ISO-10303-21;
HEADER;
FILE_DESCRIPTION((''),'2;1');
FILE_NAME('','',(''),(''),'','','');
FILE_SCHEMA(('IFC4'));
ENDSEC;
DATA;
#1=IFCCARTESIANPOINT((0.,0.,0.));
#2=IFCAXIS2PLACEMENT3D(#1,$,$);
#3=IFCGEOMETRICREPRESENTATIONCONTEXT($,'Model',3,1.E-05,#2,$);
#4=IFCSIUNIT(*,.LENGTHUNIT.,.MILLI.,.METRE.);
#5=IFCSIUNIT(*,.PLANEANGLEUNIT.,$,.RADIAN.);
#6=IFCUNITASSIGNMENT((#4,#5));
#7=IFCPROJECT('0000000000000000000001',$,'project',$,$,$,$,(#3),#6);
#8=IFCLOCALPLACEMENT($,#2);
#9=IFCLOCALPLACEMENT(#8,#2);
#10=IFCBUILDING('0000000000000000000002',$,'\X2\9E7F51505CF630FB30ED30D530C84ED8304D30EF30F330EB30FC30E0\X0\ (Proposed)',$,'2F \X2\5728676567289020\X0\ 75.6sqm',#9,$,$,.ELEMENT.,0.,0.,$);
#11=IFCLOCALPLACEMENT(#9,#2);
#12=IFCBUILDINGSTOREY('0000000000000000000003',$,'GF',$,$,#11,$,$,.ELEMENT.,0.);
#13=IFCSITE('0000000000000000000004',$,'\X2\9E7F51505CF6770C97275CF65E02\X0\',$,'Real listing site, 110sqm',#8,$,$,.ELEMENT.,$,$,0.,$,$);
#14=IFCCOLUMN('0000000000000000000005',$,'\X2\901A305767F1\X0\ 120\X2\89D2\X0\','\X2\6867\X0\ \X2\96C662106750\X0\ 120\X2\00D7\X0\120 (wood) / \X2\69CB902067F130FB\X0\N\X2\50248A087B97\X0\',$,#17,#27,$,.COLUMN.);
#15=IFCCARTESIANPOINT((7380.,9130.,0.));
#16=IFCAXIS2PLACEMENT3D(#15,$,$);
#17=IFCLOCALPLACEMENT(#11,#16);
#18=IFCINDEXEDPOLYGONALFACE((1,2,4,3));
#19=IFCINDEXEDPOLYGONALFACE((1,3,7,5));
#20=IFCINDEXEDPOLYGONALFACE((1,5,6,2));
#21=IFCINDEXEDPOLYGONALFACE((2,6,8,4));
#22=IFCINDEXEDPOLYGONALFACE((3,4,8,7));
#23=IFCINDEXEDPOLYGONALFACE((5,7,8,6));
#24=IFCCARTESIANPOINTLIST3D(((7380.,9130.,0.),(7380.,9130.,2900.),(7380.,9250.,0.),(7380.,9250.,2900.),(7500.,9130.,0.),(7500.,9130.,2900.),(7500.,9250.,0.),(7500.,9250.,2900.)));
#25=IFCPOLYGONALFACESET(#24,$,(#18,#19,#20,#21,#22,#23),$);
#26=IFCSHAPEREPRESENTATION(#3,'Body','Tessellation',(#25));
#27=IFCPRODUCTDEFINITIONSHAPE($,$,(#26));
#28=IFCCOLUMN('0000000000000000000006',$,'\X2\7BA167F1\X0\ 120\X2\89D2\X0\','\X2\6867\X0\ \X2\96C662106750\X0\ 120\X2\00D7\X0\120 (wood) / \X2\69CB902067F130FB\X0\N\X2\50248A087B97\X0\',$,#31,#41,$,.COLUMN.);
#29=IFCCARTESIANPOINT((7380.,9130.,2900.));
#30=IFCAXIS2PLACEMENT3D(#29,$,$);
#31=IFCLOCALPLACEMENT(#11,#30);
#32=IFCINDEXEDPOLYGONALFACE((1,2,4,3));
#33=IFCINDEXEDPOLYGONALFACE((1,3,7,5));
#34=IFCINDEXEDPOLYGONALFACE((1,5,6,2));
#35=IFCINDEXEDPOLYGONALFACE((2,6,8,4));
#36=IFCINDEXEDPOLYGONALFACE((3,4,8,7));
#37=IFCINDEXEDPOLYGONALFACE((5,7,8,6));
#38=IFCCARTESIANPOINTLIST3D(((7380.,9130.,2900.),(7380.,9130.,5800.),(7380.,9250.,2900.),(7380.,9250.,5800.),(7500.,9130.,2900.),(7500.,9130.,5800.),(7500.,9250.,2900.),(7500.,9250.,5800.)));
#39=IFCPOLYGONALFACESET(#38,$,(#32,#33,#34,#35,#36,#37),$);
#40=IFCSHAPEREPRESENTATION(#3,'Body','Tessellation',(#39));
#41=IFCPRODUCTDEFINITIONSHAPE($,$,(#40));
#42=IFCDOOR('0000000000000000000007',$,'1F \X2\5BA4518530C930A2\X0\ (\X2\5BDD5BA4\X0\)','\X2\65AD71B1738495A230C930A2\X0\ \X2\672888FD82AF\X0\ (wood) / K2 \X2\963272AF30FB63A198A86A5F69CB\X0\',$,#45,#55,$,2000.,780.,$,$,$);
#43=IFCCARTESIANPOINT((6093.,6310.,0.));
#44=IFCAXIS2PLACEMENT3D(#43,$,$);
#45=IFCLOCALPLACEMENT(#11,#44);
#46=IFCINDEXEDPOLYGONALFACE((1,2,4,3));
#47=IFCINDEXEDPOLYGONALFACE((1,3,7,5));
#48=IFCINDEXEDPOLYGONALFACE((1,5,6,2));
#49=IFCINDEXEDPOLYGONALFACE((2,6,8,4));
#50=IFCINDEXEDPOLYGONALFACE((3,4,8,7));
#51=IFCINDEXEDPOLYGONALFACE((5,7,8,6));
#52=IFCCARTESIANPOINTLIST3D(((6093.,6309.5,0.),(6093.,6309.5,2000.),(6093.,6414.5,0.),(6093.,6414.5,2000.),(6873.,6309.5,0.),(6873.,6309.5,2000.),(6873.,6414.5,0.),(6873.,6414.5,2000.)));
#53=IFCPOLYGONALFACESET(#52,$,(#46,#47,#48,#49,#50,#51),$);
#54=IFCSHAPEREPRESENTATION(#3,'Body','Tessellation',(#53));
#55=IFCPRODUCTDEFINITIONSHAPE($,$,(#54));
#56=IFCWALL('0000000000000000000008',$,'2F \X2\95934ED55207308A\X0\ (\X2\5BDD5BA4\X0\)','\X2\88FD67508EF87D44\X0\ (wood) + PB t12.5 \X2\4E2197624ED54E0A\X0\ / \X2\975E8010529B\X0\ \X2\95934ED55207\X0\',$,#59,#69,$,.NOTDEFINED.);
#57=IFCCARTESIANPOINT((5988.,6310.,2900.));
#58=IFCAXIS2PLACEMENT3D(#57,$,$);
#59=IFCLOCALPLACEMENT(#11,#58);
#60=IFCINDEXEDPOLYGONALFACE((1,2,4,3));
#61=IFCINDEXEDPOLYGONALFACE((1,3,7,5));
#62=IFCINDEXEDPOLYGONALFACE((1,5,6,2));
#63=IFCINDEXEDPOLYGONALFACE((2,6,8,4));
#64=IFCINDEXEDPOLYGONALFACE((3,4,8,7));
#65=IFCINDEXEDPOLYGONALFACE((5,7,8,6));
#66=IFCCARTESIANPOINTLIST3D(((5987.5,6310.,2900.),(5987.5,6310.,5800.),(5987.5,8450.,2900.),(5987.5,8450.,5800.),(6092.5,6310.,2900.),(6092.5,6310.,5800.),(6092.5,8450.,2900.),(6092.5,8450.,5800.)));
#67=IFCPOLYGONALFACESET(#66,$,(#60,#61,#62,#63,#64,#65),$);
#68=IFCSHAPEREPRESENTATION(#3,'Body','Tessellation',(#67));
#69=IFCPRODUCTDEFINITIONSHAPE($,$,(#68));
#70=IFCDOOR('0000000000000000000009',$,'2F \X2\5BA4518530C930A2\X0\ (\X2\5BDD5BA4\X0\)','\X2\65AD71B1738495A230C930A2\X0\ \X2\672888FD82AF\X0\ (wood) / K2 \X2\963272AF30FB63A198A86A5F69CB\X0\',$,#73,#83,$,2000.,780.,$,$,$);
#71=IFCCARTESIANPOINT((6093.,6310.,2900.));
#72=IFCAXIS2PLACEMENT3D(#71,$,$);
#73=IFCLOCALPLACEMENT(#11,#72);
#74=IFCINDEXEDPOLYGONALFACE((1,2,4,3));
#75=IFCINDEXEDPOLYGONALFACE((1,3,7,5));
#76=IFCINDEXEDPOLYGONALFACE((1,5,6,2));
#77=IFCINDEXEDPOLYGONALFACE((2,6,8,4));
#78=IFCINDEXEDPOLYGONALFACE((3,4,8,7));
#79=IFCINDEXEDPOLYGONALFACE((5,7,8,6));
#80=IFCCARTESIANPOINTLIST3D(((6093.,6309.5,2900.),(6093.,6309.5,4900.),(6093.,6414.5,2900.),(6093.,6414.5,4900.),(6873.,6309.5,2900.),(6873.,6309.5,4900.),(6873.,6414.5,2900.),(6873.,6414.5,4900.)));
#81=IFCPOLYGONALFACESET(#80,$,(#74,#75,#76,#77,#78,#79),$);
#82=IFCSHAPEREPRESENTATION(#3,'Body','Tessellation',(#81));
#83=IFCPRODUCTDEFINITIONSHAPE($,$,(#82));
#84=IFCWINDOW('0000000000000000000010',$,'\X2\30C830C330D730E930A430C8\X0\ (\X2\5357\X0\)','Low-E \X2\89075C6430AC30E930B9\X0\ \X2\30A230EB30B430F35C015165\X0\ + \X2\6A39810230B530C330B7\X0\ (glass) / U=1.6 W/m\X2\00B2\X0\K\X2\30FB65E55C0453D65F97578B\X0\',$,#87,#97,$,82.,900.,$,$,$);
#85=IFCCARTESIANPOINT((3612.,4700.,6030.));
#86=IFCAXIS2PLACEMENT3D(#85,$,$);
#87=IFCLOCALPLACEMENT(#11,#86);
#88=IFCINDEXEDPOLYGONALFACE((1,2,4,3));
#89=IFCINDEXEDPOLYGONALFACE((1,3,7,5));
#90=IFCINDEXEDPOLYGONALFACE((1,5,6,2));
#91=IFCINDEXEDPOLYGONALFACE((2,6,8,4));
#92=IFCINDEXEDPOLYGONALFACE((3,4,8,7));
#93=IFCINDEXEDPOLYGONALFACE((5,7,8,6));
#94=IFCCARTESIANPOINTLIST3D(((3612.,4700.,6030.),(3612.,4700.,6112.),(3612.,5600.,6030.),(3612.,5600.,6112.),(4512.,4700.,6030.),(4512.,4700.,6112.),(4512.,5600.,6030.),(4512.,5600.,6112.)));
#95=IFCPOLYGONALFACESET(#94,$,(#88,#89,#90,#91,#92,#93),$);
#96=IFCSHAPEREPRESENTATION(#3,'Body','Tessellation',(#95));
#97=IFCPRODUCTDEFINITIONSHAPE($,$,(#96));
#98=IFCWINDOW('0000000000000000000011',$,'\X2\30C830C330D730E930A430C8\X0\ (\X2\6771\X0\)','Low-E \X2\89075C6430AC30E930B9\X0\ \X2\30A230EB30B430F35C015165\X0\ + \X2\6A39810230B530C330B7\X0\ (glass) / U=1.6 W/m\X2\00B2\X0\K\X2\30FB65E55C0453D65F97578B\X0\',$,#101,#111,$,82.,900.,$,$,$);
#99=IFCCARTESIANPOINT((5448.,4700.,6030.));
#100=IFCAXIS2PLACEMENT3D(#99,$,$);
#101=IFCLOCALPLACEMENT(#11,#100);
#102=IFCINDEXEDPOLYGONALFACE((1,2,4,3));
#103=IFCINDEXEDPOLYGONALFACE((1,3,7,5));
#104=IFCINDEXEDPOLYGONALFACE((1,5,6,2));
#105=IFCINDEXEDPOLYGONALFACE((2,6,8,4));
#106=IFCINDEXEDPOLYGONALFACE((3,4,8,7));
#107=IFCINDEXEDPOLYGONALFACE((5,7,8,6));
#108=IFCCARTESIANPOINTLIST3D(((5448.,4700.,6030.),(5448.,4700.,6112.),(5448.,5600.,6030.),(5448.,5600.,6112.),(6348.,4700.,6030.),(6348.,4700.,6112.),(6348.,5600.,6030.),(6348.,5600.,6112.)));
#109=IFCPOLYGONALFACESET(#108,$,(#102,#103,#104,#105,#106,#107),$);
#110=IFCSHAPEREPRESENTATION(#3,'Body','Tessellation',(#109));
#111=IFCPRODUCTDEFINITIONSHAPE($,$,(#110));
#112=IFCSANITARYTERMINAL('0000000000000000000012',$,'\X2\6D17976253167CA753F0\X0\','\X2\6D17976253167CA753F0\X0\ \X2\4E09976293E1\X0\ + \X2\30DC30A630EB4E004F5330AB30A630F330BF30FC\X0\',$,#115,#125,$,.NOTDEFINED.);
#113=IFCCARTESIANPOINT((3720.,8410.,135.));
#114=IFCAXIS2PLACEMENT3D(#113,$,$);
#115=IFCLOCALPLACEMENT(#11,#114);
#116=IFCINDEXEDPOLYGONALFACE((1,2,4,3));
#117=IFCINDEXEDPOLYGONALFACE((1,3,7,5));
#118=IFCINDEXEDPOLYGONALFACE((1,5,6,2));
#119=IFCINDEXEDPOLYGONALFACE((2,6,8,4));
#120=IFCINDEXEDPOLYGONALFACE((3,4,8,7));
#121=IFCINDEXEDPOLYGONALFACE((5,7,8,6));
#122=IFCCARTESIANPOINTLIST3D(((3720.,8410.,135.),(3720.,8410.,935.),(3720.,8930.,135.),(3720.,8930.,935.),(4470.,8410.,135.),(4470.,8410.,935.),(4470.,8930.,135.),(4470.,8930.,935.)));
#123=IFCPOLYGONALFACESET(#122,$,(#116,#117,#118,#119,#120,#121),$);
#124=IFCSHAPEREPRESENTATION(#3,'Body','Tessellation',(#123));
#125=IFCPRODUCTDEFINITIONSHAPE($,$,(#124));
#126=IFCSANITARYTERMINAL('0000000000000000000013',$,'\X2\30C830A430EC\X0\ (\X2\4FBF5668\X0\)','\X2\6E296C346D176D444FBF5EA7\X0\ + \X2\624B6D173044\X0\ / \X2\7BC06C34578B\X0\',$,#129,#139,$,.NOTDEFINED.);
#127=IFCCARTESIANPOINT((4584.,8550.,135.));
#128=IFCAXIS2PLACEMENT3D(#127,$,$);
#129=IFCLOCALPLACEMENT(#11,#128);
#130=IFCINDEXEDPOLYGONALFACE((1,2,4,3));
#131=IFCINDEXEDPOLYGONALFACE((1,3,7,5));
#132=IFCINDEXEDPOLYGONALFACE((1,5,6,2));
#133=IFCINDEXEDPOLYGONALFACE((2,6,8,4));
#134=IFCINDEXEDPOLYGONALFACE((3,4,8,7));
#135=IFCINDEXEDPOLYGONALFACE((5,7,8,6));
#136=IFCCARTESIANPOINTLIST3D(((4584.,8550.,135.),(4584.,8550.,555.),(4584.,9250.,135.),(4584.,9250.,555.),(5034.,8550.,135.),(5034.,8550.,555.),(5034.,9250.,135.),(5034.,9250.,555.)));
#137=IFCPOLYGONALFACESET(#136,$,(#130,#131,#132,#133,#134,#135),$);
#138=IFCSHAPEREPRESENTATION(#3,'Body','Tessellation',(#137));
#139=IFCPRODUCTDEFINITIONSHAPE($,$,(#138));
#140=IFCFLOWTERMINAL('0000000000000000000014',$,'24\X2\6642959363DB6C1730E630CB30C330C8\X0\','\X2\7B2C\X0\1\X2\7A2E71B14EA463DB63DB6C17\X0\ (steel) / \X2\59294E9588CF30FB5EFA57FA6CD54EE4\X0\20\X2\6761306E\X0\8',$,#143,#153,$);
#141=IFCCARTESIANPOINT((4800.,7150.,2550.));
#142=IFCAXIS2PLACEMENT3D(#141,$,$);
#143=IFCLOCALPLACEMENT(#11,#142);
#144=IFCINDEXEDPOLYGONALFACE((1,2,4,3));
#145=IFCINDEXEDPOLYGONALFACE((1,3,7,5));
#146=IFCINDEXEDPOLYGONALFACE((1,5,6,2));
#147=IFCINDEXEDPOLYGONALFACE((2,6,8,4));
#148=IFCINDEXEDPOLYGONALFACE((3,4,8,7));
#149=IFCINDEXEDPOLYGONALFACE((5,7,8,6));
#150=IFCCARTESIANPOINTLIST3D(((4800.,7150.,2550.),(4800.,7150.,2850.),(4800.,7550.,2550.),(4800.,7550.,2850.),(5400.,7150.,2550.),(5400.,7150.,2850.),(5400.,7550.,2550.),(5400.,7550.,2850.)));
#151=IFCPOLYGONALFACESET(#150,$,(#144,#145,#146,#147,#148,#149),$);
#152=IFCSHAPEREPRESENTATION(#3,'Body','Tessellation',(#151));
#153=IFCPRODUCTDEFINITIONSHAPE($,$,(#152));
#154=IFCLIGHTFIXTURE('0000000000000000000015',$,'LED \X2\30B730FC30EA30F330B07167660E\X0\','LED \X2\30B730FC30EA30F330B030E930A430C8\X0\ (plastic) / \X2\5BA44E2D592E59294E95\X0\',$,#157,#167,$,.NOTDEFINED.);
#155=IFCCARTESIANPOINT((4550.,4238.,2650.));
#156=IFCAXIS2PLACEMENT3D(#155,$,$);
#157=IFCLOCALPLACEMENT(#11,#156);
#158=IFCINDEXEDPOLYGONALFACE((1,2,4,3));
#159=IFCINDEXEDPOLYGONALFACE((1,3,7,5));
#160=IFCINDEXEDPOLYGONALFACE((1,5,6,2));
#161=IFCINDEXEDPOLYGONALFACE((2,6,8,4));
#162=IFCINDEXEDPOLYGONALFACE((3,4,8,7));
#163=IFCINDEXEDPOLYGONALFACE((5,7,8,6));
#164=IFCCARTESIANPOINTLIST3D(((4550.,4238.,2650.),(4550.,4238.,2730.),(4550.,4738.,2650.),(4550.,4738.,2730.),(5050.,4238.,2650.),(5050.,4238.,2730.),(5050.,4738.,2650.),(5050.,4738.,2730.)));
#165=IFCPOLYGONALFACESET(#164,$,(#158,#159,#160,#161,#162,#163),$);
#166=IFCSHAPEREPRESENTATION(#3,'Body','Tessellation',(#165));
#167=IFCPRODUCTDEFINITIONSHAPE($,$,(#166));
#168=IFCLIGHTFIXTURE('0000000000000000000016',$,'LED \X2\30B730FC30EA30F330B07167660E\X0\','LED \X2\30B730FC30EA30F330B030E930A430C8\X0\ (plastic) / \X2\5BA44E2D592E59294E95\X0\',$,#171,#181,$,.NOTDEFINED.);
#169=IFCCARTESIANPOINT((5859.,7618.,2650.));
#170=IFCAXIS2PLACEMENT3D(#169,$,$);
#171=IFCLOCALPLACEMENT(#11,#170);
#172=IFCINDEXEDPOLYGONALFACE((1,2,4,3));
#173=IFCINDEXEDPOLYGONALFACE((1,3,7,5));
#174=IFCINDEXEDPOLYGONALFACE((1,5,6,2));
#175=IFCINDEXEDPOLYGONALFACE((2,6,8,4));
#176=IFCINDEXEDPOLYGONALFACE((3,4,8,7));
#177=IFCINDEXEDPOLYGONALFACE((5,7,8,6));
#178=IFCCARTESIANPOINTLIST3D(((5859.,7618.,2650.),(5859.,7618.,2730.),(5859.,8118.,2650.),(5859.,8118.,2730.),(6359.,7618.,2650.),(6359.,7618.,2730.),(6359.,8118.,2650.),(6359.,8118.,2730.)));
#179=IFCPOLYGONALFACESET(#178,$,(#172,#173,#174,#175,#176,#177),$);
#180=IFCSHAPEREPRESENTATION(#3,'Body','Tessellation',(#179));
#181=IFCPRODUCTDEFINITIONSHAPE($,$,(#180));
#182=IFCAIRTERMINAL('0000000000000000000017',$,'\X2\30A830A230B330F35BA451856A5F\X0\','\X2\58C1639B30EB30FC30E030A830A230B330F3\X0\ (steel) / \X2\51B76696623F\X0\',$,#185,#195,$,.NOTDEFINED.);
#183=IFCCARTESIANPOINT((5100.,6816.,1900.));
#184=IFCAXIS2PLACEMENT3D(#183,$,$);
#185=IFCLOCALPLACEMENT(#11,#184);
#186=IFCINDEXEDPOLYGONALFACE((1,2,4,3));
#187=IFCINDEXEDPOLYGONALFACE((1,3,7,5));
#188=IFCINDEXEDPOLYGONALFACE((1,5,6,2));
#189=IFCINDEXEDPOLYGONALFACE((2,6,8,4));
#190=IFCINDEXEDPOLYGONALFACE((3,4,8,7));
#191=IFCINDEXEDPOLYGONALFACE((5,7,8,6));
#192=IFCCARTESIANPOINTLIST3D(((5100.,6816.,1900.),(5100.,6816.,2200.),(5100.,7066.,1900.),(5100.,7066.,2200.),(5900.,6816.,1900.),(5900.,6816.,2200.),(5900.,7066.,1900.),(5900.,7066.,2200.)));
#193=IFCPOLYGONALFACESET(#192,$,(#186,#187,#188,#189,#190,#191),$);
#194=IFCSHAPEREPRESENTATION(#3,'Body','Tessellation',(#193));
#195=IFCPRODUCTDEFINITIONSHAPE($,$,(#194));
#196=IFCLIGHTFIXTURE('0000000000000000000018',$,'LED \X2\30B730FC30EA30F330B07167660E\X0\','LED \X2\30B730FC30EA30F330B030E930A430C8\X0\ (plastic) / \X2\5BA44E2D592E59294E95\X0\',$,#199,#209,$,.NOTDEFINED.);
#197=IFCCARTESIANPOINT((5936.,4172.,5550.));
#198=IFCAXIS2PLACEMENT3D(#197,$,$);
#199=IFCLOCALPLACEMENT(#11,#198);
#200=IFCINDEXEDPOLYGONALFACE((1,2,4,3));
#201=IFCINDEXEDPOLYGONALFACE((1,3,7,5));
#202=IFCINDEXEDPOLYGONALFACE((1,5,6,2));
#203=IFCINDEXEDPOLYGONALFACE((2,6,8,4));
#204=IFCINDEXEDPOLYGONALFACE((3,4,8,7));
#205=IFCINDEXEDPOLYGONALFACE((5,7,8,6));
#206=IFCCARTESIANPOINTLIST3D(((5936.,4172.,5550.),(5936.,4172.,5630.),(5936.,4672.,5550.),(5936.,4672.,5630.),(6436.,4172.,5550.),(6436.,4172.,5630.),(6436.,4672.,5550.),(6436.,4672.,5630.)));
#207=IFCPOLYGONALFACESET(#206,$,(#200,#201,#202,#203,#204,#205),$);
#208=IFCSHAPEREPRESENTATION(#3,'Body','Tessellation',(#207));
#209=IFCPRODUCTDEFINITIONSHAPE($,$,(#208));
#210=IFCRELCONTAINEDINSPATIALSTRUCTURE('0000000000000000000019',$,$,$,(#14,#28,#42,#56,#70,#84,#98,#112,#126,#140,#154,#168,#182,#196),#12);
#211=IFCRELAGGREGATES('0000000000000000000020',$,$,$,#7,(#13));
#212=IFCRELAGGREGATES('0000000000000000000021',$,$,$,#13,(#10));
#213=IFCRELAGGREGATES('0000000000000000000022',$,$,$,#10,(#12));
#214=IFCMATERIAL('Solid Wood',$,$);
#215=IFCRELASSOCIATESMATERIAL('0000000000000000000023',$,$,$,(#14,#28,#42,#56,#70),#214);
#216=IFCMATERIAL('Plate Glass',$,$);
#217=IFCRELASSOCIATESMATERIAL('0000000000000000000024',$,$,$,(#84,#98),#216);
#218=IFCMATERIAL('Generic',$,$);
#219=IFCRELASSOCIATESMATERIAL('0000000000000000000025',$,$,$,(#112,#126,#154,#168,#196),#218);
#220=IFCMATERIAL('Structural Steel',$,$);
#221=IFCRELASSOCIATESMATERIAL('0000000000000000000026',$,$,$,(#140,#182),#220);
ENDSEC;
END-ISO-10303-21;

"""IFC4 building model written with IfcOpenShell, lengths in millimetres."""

from ifc_helpers import new_model, si_unit, frame, frame_2d, origin, place, context, project, spatial, rectangle, extrude, material, element, save


model = new_model("IFC4")

# Units and contexts
model_context = context("Model", 3, precision=1e-05, world=origin())
ifc_project = project(units=[si_unit("LENGTHUNIT", "METRE", prefix="MILLI"), si_unit("PLANEANGLEUNIT", "RADIAN")], contexts=[model_context])

# Site, building, storey
site_placement = place(None, origin())
site = spatial("IfcSite", under=ifc_project, at=site_placement, Name="鹿児島県霧島市", ObjectType="Real listing site, 110sqm", CompositionType="ELEMENT", RefElevation=0.0)
building_placement = place(site_placement, origin())
building = spatial("IfcBuilding", under=site, at=building_placement, Name="鹿児島・ロフト付きワンルーム (Proposed)", ObjectType="2F 在来木造 75.6sqm", CompositionType="ELEMENT", ElevationOfRefHeight=0.0, ElevationOfTerrain=0.0)
storey_placement = place(building_placement, origin())
storey = spatial("IfcBuildingStorey", under=building, at=storey_placement, Name="GF", CompositionType="ELEMENT", Elevation=0.0)

# Columns
ifc_material_1 = material(Name="Solid Wood")
column_1_placement = place(storey_placement, frame((7380.0, 9130.0, 0.0)))
element("IfcColumn", 1, at=column_1_placement, inside=storey, material=ifc_material_1, Name="通し柱 120角", Description="桧 集成材 120×120 (wood) / 構造柱・N値計算", PredefinedType="COLUMN", context=model_context, shape_type="SweptSolid", body=[
    extrude(rectangle(XDim=120.0, YDim=120.0, at=frame_2d((60.0, 60.0))), frame((7380.0, 9130.0, 0.0)), (0.0, 0.0, 1.0), 2900.0),
])
column_2_placement = place(storey_placement, frame((7380.0, 9130.0, 2900.0)))
element("IfcColumn", 2, at=column_2_placement, inside=storey, material=ifc_material_1, Name="管柱 120角", Description="桧 集成材 120×120 (wood) / 構造柱・N値計算", PredefinedType="COLUMN", context=model_context, shape_type="SweptSolid", body=[
    extrude(rectangle(XDim=120.0, YDim=120.0, at=frame_2d((60.0, 60.0))), frame((7380.0, 9130.0, 2900.0)), (0.0, 0.0, 1.0), 2900.0),
])

# Door
door_1_placement = place(storey_placement, frame((6093.0, 6310.0, 0.0)))
element("IfcDoor", 3, at=door_1_placement, inside=storey, material=ifc_material_1, Name="1F 室内ドア (寝室)", Description="断熱玄関ドア 木製芯 (wood) / K2 防犯・採風機構", OverallHeight=2000.0, OverallWidth=780.0, context=model_context, shape_type="SweptSolid", body=[
    extrude(rectangle(XDim=780.0, YDim=105.0, at=frame_2d((390.0, 52.0))), frame((6093.0, 6310.0, 0.0)), (0.0, 0.0, 1.0), 2000.0),
])

# Wall
wall_1_placement = place(storey_placement, frame((5988.0, 6310.0, 2900.0)))
element("IfcWall", 4, at=wall_1_placement, inside=storey, material=ifc_material_1, Name="2F 間仕切り (寝室)", Description="製材軸組 (wood) + PB t12.5 両面仕上 / 非耐力 間仕切", PredefinedType="NOTDEFINED", context=model_context, shape_type="SweptSolid", body=[
    extrude(rectangle(XDim=105.0, YDim=2140.0, at=frame_2d((52.0, 1070.0))), frame((5988.0, 6310.0, 2900.0)), (0.0, 0.0, 1.0), 2900.0),
])

# Door
door_2_placement = place(storey_placement, frame((6093.0, 6310.0, 2900.0)))
element("IfcDoor", 5, at=door_2_placement, inside=storey, material=ifc_material_1, Name="2F 室内ドア (寝室)", Description="断熱玄関ドア 木製芯 (wood) / K2 防犯・採風機構", OverallHeight=2000.0, OverallWidth=780.0, context=model_context, shape_type="SweptSolid", body=[
    extrude(rectangle(XDim=780.0, YDim=105.0, at=frame_2d((390.0, 52.0))), frame((6093.0, 6310.0, 2900.0)), (0.0, 0.0, 1.0), 2000.0),
])

# Windows
ifc_material_2 = material(Name="Plate Glass")
window_1_placement = place(storey_placement, frame((3612.0, 4700.0, 6030.0)))
element("IfcWindow", 6, at=window_1_placement, inside=storey, material=ifc_material_2, Name="トップライト (南)", Description="Low-E 複層ガラス アルゴン封入 + 樹脂サッシ (glass) / U=1.6 W/m²K・日射取得型", OverallHeight=82.0, OverallWidth=900.0, context=model_context, shape_type="SweptSolid", body=[
    extrude(rectangle(XDim=900.0, YDim=900.0, at=frame_2d((450.0, 450.0))), frame((3612.0, 4700.0, 6030.0)), (0.0, 0.0, 1.0), 82.0),
])
window_2_placement = place(storey_placement, frame((5448.0, 4700.0, 6030.0)))
element("IfcWindow", 7, at=window_2_placement, inside=storey, material=ifc_material_2, Name="トップライト (東)", Description="Low-E 複層ガラス アルゴン封入 + 樹脂サッシ (glass) / U=1.6 W/m²K・日射取得型", OverallHeight=82.0, OverallWidth=900.0, context=model_context, shape_type="SweptSolid", body=[
    extrude(rectangle(XDim=900.0, YDim=900.0, at=frame_2d((450.0, 450.0))), frame((5448.0, 4700.0, 6030.0)), (0.0, 0.0, 1.0), 82.0),
])

# Sanitary terminals
ifc_material_3 = material(Name="Generic")
sanitary_terminal_1_placement = place(storey_placement, frame((3720.0, 8410.0, 135.0)))
element("IfcSanitaryTerminal", 8, at=sanitary_terminal_1_placement, inside=storey, material=ifc_material_3, Name="洗面化粧台", Description="洗面化粧台 三面鏡 + ボウル一体カウンター", PredefinedType="NOTDEFINED", context=model_context, shape_type="SweptSolid", body=[
    extrude(rectangle(XDim=750.0, YDim=520.0, at=frame_2d((375.0, 260.0))), frame((3720.0, 8410.0, 135.0)), (0.0, 0.0, 1.0), 800.0),
])
sanitary_terminal_2_placement = place(storey_placement, frame((4584.0, 8550.0, 135.0)))
element("IfcSanitaryTerminal", 9, at=sanitary_terminal_2_placement, inside=storey, material=ifc_material_3, Name="トイレ (便器)", Description="温水洗浄便座 + 手洗い / 節水型", PredefinedType="NOTDEFINED", context=model_context, shape_type="SweptSolid", body=[
    extrude(rectangle(XDim=450.0, YDim=700.0, at=frame_2d((225.0, 350.0))), frame((4584.0, 8550.0, 135.0)), (0.0, 0.0, 1.0), 420.0),
])

# Flow terminal
ifc_material_4 = material(Name="Structural Steel")
flow_terminal_placement = place(storey_placement, frame((4800.0, 7150.0, 2550.0)))
element("IfcFlowTerminal", 10, at=flow_terminal_placement, inside=storey, material=ifc_material_4, Name="24時間換気ユニット", Description="第1種熱交換換気 (steel) / 天井裏・建基法令20条の8", context=model_context, shape_type="SweptSolid", body=[
    extrude(rectangle(XDim=600.0, YDim=400.0, at=frame_2d((300.0, 200.0))), frame((4800.0, 7150.0, 2550.0)), (0.0, 0.0, 1.0), 300.0),
])

# Light fixtures
light_fixture_1_placement = place(storey_placement, frame((4550.0, 4238.0, 2650.0)))
element("IfcLightFixture", 11, at=light_fixture_1_placement, inside=storey, material=ifc_material_3, Name="LED シーリング照明", Description="LED シーリングライト (plastic) / 室中央天井", PredefinedType="NOTDEFINED", context=model_context, shape_type="SweptSolid", body=[
    extrude(rectangle(XDim=500.0, YDim=500.0, at=frame_2d((250.0, 250.0))), frame((4550.0, 4238.0, 2650.0)), (0.0, 0.0, 1.0), 80.0),
])
light_fixture_2_placement = place(storey_placement, frame((5859.0, 7618.0, 2650.0)))
element("IfcLightFixture", 12, at=light_fixture_2_placement, inside=storey, material=ifc_material_3, Name="LED シーリング照明", Description="LED シーリングライト (plastic) / 室中央天井", PredefinedType="NOTDEFINED", context=model_context, shape_type="SweptSolid", body=[
    extrude(rectangle(XDim=500.0, YDim=500.0, at=frame_2d((250.0, 250.0))), frame((5859.0, 7618.0, 2650.0)), (0.0, 0.0, 1.0), 80.0),
])

# Air terminal
air_terminal_placement = place(storey_placement, frame((5100.0, 6816.0, 1900.0)))
element("IfcAirTerminal", 13, at=air_terminal_placement, inside=storey, material=ifc_material_4, Name="エアコン室内機", Description="壁掛ルームエアコン (steel) / 冷暖房", PredefinedType="NOTDEFINED", context=model_context, shape_type="SweptSolid", body=[
    extrude(rectangle(XDim=800.0, YDim=250.0, at=frame_2d((400.0, 125.0))), frame((5100.0, 6816.0, 1900.0)), (0.0, 0.0, 1.0), 300.0),
])

# Light fixture
light_fixture_3_placement = place(storey_placement, frame((5936.0, 4172.0, 5550.0)))
element("IfcLightFixture", 14, at=light_fixture_3_placement, inside=storey, material=ifc_material_3, Name="LED シーリング照明", Description="LED シーリングライト (plastic) / 室中央天井", PredefinedType="NOTDEFINED", context=model_context, shape_type="SweptSolid", body=[
    extrude(rectangle(XDim=500.0, YDim=500.0, at=frame_2d((250.0, 250.0))), frame((5936.0, 4172.0, 5550.0)), (0.0, 0.0, 1.0), 80.0),
])

save(model, "model.ifc")
